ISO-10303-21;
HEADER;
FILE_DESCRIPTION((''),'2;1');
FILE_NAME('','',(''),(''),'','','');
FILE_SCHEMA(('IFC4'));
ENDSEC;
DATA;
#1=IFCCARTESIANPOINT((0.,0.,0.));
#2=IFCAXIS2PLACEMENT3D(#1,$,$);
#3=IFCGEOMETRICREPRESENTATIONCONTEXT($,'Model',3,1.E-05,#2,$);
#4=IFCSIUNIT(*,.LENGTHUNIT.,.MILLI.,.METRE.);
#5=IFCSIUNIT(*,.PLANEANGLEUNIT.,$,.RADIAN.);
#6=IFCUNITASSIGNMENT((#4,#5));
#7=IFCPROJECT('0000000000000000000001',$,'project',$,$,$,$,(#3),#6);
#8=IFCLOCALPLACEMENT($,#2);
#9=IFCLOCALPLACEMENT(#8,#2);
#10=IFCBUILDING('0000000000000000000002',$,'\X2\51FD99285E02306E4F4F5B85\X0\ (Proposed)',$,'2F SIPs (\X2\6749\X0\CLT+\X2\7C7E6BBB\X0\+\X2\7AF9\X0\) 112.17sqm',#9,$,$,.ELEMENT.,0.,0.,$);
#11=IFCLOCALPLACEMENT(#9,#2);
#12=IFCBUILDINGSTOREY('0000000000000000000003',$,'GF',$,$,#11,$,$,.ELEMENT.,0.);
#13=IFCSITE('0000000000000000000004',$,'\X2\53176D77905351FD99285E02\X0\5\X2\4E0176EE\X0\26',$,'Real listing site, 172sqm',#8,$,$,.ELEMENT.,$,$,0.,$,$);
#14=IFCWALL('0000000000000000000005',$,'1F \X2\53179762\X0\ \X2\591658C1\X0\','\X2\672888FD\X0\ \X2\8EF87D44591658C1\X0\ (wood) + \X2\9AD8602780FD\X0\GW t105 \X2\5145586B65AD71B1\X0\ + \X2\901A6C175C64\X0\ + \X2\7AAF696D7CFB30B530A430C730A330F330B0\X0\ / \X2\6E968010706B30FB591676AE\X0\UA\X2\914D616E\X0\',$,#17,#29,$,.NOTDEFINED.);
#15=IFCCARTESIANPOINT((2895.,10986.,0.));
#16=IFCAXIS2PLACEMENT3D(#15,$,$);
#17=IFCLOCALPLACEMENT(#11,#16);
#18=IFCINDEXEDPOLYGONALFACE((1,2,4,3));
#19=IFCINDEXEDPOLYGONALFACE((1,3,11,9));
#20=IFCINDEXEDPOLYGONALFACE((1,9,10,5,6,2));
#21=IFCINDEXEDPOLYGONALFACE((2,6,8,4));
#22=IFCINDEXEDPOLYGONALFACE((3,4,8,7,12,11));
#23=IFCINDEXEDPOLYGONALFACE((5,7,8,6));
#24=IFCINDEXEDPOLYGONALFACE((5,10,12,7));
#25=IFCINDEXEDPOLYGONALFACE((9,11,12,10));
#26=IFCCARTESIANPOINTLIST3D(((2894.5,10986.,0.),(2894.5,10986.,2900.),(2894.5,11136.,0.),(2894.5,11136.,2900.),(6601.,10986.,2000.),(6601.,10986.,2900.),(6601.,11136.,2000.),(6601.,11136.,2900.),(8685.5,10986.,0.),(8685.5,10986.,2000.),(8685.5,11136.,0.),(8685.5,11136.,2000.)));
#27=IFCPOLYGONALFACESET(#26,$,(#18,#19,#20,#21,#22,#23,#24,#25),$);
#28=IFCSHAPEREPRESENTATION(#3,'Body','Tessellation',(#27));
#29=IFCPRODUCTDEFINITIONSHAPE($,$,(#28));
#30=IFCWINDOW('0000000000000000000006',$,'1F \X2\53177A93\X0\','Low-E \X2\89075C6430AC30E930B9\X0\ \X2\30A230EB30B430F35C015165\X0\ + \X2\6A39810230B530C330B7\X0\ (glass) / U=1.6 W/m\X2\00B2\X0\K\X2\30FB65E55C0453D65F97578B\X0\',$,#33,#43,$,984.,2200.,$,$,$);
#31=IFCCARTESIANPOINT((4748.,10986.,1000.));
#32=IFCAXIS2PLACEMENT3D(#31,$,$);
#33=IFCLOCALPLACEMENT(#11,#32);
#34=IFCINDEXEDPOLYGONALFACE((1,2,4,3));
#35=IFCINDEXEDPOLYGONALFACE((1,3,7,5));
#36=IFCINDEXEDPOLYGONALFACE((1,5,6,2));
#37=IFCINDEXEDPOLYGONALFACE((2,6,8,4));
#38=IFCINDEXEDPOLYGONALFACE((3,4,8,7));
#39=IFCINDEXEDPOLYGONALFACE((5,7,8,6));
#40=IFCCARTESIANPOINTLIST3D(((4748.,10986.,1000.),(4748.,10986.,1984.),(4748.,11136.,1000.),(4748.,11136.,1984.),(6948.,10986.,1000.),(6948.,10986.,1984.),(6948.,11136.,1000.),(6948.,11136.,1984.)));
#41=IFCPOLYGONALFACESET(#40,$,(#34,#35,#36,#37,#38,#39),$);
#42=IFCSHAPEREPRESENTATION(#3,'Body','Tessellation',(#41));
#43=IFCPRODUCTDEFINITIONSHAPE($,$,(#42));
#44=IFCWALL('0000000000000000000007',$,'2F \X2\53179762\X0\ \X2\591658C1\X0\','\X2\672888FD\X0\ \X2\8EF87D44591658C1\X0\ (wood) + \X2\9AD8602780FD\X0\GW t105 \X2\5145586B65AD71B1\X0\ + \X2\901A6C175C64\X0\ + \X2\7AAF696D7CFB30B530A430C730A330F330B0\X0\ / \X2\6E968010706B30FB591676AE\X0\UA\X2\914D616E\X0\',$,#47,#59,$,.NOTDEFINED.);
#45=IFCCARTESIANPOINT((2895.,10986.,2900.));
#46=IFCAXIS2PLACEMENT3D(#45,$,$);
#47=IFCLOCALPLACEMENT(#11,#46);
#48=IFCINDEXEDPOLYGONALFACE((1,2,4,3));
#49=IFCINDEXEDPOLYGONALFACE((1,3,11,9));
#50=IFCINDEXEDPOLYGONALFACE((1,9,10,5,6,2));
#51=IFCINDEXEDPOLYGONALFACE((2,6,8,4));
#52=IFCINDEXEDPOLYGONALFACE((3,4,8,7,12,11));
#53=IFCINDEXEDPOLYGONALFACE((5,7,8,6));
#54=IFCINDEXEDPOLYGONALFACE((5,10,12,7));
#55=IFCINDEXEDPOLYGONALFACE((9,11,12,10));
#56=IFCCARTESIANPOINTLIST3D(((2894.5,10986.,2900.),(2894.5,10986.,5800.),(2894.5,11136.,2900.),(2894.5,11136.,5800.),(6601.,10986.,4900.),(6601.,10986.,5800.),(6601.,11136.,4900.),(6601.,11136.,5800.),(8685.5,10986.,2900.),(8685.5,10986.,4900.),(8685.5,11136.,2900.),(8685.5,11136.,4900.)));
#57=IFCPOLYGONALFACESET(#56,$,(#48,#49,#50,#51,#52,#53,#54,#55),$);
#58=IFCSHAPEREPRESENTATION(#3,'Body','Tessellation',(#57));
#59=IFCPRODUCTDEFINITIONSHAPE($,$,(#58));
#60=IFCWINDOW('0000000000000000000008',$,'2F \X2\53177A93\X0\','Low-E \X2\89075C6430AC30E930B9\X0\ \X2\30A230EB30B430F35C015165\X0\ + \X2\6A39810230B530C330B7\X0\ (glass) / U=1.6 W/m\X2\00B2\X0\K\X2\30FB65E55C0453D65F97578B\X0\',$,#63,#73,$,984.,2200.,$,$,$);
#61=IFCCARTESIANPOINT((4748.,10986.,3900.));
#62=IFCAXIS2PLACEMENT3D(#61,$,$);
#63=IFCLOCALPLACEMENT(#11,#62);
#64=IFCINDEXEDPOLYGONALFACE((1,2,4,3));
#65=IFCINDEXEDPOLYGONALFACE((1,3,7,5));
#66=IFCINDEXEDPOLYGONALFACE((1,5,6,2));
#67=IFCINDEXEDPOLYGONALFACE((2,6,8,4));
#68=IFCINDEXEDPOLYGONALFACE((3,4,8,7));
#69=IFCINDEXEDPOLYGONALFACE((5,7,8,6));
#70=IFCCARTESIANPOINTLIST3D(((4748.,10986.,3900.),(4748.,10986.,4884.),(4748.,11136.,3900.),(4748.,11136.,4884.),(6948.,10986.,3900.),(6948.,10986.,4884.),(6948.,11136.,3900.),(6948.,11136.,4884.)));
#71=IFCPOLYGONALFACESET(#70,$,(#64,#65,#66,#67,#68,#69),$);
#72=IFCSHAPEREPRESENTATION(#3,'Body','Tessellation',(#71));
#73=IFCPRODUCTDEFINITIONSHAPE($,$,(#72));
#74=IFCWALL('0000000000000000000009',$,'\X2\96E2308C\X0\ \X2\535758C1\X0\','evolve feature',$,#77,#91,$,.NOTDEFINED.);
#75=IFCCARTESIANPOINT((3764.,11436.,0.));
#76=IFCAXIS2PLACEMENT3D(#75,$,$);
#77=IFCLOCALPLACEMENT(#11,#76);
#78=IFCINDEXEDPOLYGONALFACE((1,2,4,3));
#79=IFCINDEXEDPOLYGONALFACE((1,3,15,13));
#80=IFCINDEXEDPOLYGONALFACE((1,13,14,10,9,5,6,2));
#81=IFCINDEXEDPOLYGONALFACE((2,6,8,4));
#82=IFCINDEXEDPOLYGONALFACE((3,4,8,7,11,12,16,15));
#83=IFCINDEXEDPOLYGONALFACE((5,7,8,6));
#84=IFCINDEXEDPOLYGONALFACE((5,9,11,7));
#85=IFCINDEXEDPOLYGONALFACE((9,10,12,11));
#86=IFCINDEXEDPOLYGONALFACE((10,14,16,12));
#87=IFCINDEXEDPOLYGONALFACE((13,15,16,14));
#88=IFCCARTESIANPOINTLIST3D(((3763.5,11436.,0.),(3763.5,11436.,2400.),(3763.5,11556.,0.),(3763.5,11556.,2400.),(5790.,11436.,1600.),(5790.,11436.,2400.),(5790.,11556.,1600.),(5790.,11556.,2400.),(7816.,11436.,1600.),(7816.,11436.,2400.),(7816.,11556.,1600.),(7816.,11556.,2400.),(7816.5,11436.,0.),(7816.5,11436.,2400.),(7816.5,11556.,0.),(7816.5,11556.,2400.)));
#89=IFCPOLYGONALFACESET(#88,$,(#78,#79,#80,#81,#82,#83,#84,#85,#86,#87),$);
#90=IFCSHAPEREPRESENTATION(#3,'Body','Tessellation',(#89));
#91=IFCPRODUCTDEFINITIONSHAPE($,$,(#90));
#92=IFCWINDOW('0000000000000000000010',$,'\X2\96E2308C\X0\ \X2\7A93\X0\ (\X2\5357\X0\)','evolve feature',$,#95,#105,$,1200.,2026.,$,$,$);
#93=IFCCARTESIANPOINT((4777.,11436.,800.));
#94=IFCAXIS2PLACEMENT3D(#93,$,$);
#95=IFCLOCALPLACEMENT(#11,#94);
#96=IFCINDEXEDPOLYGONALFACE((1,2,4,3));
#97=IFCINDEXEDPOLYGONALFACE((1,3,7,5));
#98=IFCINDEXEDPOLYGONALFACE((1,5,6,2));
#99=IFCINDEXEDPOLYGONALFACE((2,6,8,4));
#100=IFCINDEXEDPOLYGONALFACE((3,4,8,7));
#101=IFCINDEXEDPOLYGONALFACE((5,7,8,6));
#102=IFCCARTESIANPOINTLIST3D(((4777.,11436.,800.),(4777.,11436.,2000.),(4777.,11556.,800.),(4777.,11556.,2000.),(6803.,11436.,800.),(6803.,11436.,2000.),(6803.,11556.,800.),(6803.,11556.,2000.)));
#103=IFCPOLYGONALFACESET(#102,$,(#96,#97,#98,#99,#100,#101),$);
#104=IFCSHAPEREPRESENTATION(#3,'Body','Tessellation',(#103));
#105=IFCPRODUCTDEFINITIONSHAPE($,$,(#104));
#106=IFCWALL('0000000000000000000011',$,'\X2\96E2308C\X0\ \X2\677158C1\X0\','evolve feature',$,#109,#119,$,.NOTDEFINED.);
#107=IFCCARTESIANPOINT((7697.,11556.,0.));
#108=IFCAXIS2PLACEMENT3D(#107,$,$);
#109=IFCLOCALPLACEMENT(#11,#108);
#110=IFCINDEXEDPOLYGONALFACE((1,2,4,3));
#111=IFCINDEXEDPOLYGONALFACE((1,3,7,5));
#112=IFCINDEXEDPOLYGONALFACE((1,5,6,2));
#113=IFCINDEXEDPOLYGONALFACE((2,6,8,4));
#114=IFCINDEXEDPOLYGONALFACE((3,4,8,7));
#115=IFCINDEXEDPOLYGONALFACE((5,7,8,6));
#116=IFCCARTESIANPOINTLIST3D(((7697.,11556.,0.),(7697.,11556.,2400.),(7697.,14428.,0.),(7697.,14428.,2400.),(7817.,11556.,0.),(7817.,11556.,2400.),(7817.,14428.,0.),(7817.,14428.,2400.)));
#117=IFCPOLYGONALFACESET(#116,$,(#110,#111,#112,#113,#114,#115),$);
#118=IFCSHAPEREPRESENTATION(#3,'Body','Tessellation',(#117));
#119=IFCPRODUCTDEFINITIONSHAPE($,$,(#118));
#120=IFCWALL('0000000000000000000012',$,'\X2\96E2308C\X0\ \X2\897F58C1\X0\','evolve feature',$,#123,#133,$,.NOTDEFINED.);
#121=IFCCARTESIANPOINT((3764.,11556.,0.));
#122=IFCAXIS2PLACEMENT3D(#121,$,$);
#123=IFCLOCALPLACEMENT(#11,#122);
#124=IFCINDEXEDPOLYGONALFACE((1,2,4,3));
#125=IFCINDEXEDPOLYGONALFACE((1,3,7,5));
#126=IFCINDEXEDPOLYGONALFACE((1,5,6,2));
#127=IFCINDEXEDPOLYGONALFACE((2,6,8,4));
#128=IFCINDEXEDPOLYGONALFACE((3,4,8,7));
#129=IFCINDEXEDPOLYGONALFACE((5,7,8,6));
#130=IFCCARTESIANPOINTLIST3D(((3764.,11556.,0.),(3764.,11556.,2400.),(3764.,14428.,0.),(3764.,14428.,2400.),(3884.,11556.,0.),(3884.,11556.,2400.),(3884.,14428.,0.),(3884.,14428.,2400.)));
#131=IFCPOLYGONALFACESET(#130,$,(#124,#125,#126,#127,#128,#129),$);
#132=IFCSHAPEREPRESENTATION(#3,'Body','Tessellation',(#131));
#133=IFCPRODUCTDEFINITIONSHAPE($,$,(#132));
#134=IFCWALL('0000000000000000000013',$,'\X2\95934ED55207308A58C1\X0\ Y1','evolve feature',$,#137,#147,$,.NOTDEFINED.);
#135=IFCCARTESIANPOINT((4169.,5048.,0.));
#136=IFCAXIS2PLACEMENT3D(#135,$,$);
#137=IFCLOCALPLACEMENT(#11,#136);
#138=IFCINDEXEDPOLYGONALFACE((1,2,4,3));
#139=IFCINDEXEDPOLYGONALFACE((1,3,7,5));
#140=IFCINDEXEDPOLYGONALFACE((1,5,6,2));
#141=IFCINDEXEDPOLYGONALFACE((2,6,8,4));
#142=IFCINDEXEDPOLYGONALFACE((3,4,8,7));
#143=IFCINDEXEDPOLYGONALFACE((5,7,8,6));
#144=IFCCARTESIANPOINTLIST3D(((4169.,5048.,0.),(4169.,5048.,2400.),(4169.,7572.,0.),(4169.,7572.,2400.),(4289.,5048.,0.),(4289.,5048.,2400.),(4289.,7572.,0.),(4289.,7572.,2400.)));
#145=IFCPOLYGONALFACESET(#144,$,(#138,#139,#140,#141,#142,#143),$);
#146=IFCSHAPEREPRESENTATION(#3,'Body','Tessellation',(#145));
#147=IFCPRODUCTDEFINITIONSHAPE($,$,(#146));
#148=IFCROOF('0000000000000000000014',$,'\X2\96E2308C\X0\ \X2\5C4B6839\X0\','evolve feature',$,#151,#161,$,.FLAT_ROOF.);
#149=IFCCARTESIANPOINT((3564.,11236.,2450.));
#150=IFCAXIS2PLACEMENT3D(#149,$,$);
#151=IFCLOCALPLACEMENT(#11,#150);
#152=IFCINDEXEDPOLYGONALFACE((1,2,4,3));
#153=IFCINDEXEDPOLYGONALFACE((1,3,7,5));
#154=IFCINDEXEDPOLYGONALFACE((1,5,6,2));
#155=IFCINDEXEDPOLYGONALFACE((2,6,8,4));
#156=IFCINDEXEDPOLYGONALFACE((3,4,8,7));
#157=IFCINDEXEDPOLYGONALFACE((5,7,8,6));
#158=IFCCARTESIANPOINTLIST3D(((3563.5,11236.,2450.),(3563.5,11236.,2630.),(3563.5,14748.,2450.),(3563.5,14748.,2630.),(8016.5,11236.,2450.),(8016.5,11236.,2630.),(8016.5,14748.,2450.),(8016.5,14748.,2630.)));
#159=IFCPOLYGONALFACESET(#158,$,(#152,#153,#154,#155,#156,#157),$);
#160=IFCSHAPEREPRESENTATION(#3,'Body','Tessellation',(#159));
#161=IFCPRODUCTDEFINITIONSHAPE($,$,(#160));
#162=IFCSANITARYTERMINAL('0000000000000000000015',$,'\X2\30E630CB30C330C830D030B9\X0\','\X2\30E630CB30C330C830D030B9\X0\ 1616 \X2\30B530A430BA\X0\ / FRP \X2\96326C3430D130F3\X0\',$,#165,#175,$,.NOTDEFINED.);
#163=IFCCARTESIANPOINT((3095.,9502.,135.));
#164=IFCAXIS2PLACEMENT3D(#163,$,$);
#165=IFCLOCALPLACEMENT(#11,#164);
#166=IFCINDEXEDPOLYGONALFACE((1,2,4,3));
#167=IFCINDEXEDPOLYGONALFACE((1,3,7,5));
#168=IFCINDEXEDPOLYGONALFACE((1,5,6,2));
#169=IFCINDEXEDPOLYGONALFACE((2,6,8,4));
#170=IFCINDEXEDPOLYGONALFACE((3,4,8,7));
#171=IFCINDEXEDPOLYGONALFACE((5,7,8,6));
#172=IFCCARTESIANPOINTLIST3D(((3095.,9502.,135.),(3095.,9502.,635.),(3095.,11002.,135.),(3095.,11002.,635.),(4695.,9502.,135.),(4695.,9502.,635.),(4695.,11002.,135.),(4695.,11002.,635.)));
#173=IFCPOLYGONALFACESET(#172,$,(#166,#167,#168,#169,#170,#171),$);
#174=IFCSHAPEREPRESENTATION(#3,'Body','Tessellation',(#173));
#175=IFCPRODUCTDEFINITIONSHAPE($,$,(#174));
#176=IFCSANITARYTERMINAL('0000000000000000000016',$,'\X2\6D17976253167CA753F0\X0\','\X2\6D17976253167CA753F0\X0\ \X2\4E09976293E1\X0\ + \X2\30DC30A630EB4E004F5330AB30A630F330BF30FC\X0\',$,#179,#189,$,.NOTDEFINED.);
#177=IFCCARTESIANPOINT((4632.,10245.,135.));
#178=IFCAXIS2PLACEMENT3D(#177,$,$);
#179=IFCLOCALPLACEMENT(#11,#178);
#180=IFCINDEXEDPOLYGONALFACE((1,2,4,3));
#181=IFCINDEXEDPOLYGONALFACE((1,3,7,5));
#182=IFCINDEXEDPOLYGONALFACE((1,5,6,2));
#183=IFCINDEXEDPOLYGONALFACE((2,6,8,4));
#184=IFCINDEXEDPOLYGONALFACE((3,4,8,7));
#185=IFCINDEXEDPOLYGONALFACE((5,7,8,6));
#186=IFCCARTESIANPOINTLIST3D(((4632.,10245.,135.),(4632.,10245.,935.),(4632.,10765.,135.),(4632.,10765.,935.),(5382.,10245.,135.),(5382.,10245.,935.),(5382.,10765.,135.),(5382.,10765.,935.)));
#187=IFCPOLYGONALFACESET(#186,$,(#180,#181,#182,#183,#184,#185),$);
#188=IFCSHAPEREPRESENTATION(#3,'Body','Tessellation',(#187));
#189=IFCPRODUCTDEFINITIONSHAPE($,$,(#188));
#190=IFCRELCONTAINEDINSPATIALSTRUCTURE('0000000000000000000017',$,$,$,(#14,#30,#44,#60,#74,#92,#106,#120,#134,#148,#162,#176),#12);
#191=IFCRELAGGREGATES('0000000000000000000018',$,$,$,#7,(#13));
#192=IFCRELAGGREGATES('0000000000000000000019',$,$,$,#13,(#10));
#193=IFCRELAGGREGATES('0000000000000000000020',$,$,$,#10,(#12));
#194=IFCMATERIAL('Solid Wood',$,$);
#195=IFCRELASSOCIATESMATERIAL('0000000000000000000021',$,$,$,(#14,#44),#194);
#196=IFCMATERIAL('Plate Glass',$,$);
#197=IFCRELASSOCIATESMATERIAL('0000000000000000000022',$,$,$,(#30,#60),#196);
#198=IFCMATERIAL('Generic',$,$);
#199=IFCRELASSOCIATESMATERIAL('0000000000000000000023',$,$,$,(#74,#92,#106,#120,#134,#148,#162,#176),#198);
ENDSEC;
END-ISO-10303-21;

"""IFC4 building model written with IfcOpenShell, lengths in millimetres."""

from ifc_helpers import new_model, si_unit, frame, frame_2d, origin, place, context, project, spatial, rectangle, extrude, material, element, fill, save


model = new_model("IFC4")

# Units and contexts
model_context = context("Model", 3, precision=1e-05, world=origin())
ifc_project = project(units=[si_unit("LENGTHUNIT", "METRE", prefix="MILLI"), si_unit("PLANEANGLEUNIT", "RADIAN")], contexts=[model_context])

# Site, building, storey
site_placement = place(None, origin())
site = spatial("IfcSite", under=ifc_project, at=site_placement, Name="北海道函館市5丁目26", ObjectType="Real listing site, 172sqm", CompositionType="ELEMENT", RefElevation=0.0)
building_placement = place(site_placement, origin())
building = spatial("IfcBuilding", under=site, at=building_placement, Name="函館市の住宅 (Proposed)", ObjectType="2F SIPs (杉CLT+籾殻+竹) 112.17sqm", CompositionType="ELEMENT", ElevationOfRefHeight=0.0, ElevationOfTerrain=0.0)
storey_placement = place(building_placement, origin())
storey = spatial("IfcBuildingStorey", under=building, at=storey_placement, Name="GF", CompositionType="ELEMENT", Elevation=0.0)

# Shared definitions
ifc_material_1 = material(Name="Generic")

# Wall, opening, window
ifc_material_2 = material(Name="Solid Wood")
wall_1_placement = place(storey_placement, frame((2895.0, 10986.0, 0.0)))
wall_1 = element("IfcWall", 1, at=wall_1_placement, inside=storey, material=ifc_material_2, Name="1F 北面 外壁", Description="木製 軸組外壁 (wood) + 高性能GW t105 充填断熱 + 通気層 + 窯業系サイディング / 準耐火・外皮UA配慮", PredefinedType="NOTDEFINED", context=model_context, shape_type="SweptSolid", body=[
    extrude(rectangle(XDim=5791.0, YDim=150.0, at=frame_2d((2895.0, 75.0))), frame((2895.0, 10986.0, 0.0)), (0.0, 0.0, 1.0), 2900.0),
])
opening_1_placement = place(storey_placement, frame((4748.0, 10986.0, 1000.0)))
opening_1 = element("IfcOpeningElement", 2, at=opening_1_placement, cuts=wall_1, PredefinedType="NOTDEFINED", context=model_context, shape_type="SweptSolid", body=[
    extrude(rectangle(XDim=2200.0, YDim=150.0, at=frame_2d((1100.0, 75.0))), frame((4748.0, 10986.0, 1000.0)), (0.0, 0.0, 1.0), 984.0),
])
ifc_material_3 = material(Name="Plate Glass")
window_1_placement = place(storey_placement, frame((4748.0, 10986.0, 1000.0)))
window_1 = element("IfcWindow", 3, at=window_1_placement, inside=storey, material=ifc_material_3, Name="1F 北窓", Description="Low-E 複層ガラス アルゴン封入 + 樹脂サッシ (glass) / U=1.6 W/m²K・日射取得型", OverallHeight=984.0, OverallWidth=2200.0, context=model_context, shape_type="SweptSolid", body=[
    extrude(rectangle(XDim=2200.0, YDim=150.0, at=frame_2d((1100.0, 75.0))), frame((4748.0, 10986.0, 1000.0)), (0.0, 0.0, 1.0), 984.0),
])
fill(opening_1, window_1)

# Wall, opening, window
wall_2_placement = place(storey_placement, frame((2895.0, 10986.0, 2900.0)))
wall_2 = element("IfcWall", 4, at=wall_2_placement, inside=storey, material=ifc_material_2, Name="2F 北面 外壁", Description="木製 軸組外壁 (wood) + 高性能GW t105 充填断熱 + 通気層 + 窯業系サイディング / 準耐火・外皮UA配慮", PredefinedType="NOTDEFINED", context=model_context, shape_type="SweptSolid", body=[
    extrude(rectangle(XDim=5791.0, YDim=150.0, at=frame_2d((2895.0, 75.0))), frame((2895.0, 10986.0, 2900.0)), (0.0, 0.0, 1.0), 2900.0),
])
opening_2_placement = place(storey_placement, frame((4748.0, 10986.0, 3900.0)))
opening_2 = element("IfcOpeningElement", 5, at=opening_2_placement, cuts=wall_2, PredefinedType="NOTDEFINED", context=model_context, shape_type="SweptSolid", body=[
    extrude(rectangle(XDim=2200.0, YDim=150.0, at=frame_2d((1100.0, 75.0))), frame((4748.0, 10986.0, 3900.0)), (0.0, 0.0, 1.0), 984.0),
])
window_2_placement = place(storey_placement, frame((4748.0, 10986.0, 3900.0)))
window_2 = element("IfcWindow", 6, at=window_2_placement, inside=storey, material=ifc_material_3, Name="2F 北窓", Description="Low-E 複層ガラス アルゴン封入 + 樹脂サッシ (glass) / U=1.6 W/m²K・日射取得型", OverallHeight=984.0, OverallWidth=2200.0, context=model_context, shape_type="SweptSolid", body=[
    extrude(rectangle(XDim=2200.0, YDim=150.0, at=frame_2d((1100.0, 75.0))), frame((4748.0, 10986.0, 3900.0)), (0.0, 0.0, 1.0), 984.0),
])
fill(opening_2, window_2)

# Wall, opening, window
wall_3_placement = place(storey_placement, frame((3764.0, 11436.0, 0.0)))
wall_3 = element("IfcWall", 7, at=wall_3_placement, inside=storey, material=ifc_material_1, Name="離れ 南壁", Description="evolve feature", PredefinedType="NOTDEFINED", context=model_context, shape_type="SweptSolid", body=[
    extrude(rectangle(XDim=4053.0, YDim=120.0, at=frame_2d((2026.0, 60.0))), frame((3764.0, 11436.0, 0.0)), (0.0, 0.0, 1.0), 2400.0),
])
opening_3_placement = place(storey_placement, frame((4777.0, 11436.0, 800.0)))
opening_3 = element("IfcOpeningElement", 8, at=opening_3_placement, cuts=wall_3, PredefinedType="NOTDEFINED", context=model_context, shape_type="SweptSolid", body=[
    extrude(rectangle(XDim=2026.0, YDim=120.0, at=frame_2d((1013.0, 60.0))), frame((4777.0, 11436.0, 800.0)), (0.0, 0.0, 1.0), 1200.0),
])
window_3_placement = place(storey_placement, frame((4777.0, 11436.0, 800.0)))
window_3 = element("IfcWindow", 9, at=window_3_placement, inside=storey, material=ifc_material_1, Name="離れ 窓 (南)", Description="evolve feature", OverallHeight=1200.0, OverallWidth=2026.0, context=model_context, shape_type="SweptSolid", body=[
    extrude(rectangle(XDim=2026.0, YDim=120.0, at=frame_2d((1013.0, 60.0))), frame((4777.0, 11436.0, 800.0)), (0.0, 0.0, 1.0), 1200.0),
])
fill(opening_3, window_3)

# Walls
wall_4_placement = place(storey_placement, frame((7697.0, 11556.0, 0.0)))
element("IfcWall", 10, at=wall_4_placement, inside=storey, material=ifc_material_1, Name="離れ 東壁", Description="evolve feature", PredefinedType="NOTDEFINED", context=model_context, shape_type="SweptSolid", body=[
    extrude(rectangle(XDim=120.0, YDim=2872.0, at=frame_2d((60.0, 1436.0))), frame((7697.0, 11556.0, 0.0)), (0.0, 0.0, 1.0), 2400.0),
])
wall_5_placement = place(storey_placement, frame((3764.0, 11556.0, 0.0)))
element("IfcWall", 11, at=wall_5_placement, inside=storey, material=ifc_material_1, Name="離れ 西壁", Description="evolve feature", PredefinedType="NOTDEFINED", context=model_context, shape_type="SweptSolid", body=[
    extrude(rectangle(XDim=120.0, YDim=2872.0, at=frame_2d((60.0, 1436.0))), frame((3764.0, 11556.0, 0.0)), (0.0, 0.0, 1.0), 2400.0),
])
wall_6_placement = place(storey_placement, frame((4169.0, 5048.0, 0.0)))
element("IfcWall", 12, at=wall_6_placement, inside=storey, material=ifc_material_1, Name="間仕切り壁 Y1", Description="evolve feature", PredefinedType="NOTDEFINED", context=model_context, shape_type="SweptSolid", body=[
    extrude(rectangle(XDim=120.0, YDim=2524.0, at=frame_2d((60.0, 1262.0))), frame((4169.0, 5048.0, 0.0)), (0.0, 0.0, 1.0), 2400.0),
])

# Roof
roof_1_placement = place(storey_placement, frame((3564.0, 11236.0, 2450.0)))
element("IfcRoof", 13, at=roof_1_placement, inside=storey, material=ifc_material_1, Name="離れ 屋根", Description="evolve feature", PredefinedType="FLAT_ROOF", context=model_context, shape_type="SweptSolid", body=[
    extrude(rectangle(XDim=4453.0, YDim=3512.0, at=frame_2d((2226.0, 1756.0))), frame((3564.0, 11236.0, 2450.0)), (0.0, 0.0, 1.0), 180.0),
])

# Sanitary terminals
sanitary_terminal_1_placement = place(storey_placement, frame((3095.0, 9502.0, 135.0)))
element("IfcSanitaryTerminal", 14, at=sanitary_terminal_1_placement, inside=storey, material=ifc_material_1, Name="ユニットバス", Description="ユニットバス 1616 サイズ / FRP 防水パン", PredefinedType="NOTDEFINED", context=model_context, shape_type="SweptSolid", body=[
    extrude(rectangle(XDim=1600.0, YDim=1500.0, at=frame_2d((800.0, 750.0))), frame((3095.0, 9502.0, 135.0)), (0.0, 0.0, 1.0), 500.0),
])
sanitary_terminal_2_placement = place(storey_placement, frame((4632.0, 10245.0, 135.0)))
element("IfcSanitaryTerminal", 15, at=sanitary_terminal_2_placement, inside=storey, material=ifc_material_1, Name="洗面化粧台", Description="洗面化粧台 三面鏡 + ボウル一体カウンター", PredefinedType="NOTDEFINED", context=model_context, shape_type="SweptSolid", body=[
    extrude(rectangle(XDim=750.0, YDim=520.0, at=frame_2d((375.0, 260.0))), frame((4632.0, 10245.0, 135.0)), (0.0, 0.0, 1.0), 800.0),
])

save(model, "model.ifc")
